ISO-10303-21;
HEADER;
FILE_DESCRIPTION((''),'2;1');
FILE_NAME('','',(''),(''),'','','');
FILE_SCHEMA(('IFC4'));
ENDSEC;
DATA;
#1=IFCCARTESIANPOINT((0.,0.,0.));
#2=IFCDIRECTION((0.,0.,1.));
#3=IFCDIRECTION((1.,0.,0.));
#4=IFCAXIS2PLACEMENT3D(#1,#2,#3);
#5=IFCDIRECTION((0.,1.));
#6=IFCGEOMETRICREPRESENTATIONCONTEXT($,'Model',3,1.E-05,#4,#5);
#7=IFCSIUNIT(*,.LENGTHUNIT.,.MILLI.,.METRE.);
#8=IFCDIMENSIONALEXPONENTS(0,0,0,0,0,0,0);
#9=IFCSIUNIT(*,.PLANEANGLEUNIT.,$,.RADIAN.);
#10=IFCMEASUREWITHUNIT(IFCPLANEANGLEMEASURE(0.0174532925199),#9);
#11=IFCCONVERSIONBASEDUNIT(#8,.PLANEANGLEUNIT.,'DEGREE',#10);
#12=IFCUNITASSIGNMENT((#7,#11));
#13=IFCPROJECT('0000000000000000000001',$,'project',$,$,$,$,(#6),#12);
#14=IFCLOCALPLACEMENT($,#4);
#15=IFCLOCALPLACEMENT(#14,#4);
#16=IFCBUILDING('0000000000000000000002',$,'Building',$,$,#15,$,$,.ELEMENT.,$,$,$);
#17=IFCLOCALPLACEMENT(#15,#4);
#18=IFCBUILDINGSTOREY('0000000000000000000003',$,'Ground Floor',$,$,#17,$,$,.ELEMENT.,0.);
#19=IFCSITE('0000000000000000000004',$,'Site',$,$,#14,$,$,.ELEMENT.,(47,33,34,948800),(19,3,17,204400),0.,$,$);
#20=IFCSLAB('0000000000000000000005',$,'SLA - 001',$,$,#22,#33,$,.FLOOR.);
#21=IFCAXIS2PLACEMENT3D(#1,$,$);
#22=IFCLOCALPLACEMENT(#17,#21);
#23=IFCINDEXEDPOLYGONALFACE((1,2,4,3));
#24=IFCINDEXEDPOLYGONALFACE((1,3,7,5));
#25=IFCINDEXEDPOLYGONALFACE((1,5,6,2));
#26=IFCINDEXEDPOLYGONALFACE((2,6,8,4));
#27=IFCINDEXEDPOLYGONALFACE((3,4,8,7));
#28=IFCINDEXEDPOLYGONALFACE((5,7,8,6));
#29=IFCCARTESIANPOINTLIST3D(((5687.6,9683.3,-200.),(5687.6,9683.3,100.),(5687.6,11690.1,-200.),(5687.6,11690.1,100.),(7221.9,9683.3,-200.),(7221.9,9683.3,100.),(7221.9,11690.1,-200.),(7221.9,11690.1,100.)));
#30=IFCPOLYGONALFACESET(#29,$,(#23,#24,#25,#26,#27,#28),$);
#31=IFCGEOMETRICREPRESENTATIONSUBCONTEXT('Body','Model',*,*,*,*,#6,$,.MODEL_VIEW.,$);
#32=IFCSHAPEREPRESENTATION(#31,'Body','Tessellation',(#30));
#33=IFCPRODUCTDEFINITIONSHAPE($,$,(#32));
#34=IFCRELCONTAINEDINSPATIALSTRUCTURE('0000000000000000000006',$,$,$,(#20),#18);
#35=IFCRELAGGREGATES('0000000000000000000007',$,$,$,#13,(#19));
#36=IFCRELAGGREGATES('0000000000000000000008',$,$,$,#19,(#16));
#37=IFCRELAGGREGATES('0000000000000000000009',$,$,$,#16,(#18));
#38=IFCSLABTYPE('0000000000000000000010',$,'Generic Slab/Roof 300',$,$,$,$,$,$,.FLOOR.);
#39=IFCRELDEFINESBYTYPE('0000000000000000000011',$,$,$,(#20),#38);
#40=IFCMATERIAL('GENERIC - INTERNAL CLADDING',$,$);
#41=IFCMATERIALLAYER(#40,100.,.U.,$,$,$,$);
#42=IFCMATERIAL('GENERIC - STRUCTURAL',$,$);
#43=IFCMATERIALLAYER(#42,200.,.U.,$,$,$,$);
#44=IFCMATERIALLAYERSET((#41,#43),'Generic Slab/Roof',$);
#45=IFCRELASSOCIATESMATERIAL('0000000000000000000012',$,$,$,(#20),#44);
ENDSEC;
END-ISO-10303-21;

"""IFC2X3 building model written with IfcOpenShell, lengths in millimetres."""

from ifc_helpers import new_model, entity, si_unit, converted_unit, direction, frame, origin_with_axes, place, context, subcontext, project, spatial, polyline, outline, extrude, material, layer, layer_set, layer_usage, type_object, element, save


model = new_model("IFC2X3")

# Units and contexts
model_context = context("Model", 3, precision=1e-05, world=origin_with_axes(), true_north=direction((0.0, 1.0)))
body_context = subcontext(model_context, "Body", "Model", "MODEL_VIEW")
ifc_project = project(units=[si_unit("LENGTHUNIT", "METRE", prefix="MILLI"), converted_unit("PLANEANGLEUNIT", "DEGREE", entity("IfcPlaneAngleMeasure", 0.0174532925199), si_unit("PLANEANGLEUNIT", "RADIAN"), dimensions=[0, 0, 0, 0, 0, 0, 0])], contexts=[model_context])

# Site, building, storey
site_placement = place(None, origin_with_axes())
site = spatial("IfcSite", under=ifc_project, at=site_placement, Name="Site", CompositionType="ELEMENT", RefLatitude=(47, 33, 34, 948800), RefLongitude=(19, 3, 17, 204400), RefElevation=0.0)
building_placement = place(site_placement, origin_with_axes())
building = spatial("IfcBuilding", under=site, at=building_placement, Name="Building", CompositionType="ELEMENT")
storey_placement = place(building_placement, origin_with_axes())
storey = spatial("IfcBuildingStorey", under=building, at=storey_placement, Name="Ground Floor", CompositionType="ELEMENT", Elevation=0.0)

# Slab
ifc_material_1 = material(Name="GENERIC - INTERNAL CLADDING")
ifc_layer_1 = layer(ifc_material_1, 100.0, ventilated="UNKNOWN")
ifc_material_2 = material(Name="GENERIC - STRUCTURAL")
ifc_layer_2 = layer(ifc_material_2, 200.0, ventilated="UNKNOWN")
ifc_layer_set = layer_set([ifc_layer_1, ifc_layer_2], Name="Generic Slab/Roof")
ifc_layer_usage = layer_usage(ifc_layer_set, "AXIS3", "NEGATIVE", 300.0)
slab_type = type_object("IfcSlabType", Name="Generic Slab/Roof 300", PredefinedType="FLOOR")
slab_placement = place(storey_placement, frame((5687.6, 9683.3, 0.0), z_axis=(0.0, 0.0, 1.0), x_axis=(1.0, 0.0, 0.0)))
element("IfcSlab", 1, at=slab_placement, inside=storey, type_object=slab_type, material=ifc_layer_usage, Name="SLA - 001", PredefinedType="FLOOR", context=body_context, shape_type="SweptSolid", body=[
    extrude(outline(polyline([(0.0, 0.0), (1534.3, 0.0), (1534.3, 2006.7), (0.0, 2006.7), (0.0, 0.0)])), frame((0.0, 0.0, -200.0), z_axis=(0.0, 0.0, 1.0), x_axis=(1.0, 0.0, 0.0)), (0.0, 0.0, 1.0), 300.0),
])

save(model, "model.ifc")
